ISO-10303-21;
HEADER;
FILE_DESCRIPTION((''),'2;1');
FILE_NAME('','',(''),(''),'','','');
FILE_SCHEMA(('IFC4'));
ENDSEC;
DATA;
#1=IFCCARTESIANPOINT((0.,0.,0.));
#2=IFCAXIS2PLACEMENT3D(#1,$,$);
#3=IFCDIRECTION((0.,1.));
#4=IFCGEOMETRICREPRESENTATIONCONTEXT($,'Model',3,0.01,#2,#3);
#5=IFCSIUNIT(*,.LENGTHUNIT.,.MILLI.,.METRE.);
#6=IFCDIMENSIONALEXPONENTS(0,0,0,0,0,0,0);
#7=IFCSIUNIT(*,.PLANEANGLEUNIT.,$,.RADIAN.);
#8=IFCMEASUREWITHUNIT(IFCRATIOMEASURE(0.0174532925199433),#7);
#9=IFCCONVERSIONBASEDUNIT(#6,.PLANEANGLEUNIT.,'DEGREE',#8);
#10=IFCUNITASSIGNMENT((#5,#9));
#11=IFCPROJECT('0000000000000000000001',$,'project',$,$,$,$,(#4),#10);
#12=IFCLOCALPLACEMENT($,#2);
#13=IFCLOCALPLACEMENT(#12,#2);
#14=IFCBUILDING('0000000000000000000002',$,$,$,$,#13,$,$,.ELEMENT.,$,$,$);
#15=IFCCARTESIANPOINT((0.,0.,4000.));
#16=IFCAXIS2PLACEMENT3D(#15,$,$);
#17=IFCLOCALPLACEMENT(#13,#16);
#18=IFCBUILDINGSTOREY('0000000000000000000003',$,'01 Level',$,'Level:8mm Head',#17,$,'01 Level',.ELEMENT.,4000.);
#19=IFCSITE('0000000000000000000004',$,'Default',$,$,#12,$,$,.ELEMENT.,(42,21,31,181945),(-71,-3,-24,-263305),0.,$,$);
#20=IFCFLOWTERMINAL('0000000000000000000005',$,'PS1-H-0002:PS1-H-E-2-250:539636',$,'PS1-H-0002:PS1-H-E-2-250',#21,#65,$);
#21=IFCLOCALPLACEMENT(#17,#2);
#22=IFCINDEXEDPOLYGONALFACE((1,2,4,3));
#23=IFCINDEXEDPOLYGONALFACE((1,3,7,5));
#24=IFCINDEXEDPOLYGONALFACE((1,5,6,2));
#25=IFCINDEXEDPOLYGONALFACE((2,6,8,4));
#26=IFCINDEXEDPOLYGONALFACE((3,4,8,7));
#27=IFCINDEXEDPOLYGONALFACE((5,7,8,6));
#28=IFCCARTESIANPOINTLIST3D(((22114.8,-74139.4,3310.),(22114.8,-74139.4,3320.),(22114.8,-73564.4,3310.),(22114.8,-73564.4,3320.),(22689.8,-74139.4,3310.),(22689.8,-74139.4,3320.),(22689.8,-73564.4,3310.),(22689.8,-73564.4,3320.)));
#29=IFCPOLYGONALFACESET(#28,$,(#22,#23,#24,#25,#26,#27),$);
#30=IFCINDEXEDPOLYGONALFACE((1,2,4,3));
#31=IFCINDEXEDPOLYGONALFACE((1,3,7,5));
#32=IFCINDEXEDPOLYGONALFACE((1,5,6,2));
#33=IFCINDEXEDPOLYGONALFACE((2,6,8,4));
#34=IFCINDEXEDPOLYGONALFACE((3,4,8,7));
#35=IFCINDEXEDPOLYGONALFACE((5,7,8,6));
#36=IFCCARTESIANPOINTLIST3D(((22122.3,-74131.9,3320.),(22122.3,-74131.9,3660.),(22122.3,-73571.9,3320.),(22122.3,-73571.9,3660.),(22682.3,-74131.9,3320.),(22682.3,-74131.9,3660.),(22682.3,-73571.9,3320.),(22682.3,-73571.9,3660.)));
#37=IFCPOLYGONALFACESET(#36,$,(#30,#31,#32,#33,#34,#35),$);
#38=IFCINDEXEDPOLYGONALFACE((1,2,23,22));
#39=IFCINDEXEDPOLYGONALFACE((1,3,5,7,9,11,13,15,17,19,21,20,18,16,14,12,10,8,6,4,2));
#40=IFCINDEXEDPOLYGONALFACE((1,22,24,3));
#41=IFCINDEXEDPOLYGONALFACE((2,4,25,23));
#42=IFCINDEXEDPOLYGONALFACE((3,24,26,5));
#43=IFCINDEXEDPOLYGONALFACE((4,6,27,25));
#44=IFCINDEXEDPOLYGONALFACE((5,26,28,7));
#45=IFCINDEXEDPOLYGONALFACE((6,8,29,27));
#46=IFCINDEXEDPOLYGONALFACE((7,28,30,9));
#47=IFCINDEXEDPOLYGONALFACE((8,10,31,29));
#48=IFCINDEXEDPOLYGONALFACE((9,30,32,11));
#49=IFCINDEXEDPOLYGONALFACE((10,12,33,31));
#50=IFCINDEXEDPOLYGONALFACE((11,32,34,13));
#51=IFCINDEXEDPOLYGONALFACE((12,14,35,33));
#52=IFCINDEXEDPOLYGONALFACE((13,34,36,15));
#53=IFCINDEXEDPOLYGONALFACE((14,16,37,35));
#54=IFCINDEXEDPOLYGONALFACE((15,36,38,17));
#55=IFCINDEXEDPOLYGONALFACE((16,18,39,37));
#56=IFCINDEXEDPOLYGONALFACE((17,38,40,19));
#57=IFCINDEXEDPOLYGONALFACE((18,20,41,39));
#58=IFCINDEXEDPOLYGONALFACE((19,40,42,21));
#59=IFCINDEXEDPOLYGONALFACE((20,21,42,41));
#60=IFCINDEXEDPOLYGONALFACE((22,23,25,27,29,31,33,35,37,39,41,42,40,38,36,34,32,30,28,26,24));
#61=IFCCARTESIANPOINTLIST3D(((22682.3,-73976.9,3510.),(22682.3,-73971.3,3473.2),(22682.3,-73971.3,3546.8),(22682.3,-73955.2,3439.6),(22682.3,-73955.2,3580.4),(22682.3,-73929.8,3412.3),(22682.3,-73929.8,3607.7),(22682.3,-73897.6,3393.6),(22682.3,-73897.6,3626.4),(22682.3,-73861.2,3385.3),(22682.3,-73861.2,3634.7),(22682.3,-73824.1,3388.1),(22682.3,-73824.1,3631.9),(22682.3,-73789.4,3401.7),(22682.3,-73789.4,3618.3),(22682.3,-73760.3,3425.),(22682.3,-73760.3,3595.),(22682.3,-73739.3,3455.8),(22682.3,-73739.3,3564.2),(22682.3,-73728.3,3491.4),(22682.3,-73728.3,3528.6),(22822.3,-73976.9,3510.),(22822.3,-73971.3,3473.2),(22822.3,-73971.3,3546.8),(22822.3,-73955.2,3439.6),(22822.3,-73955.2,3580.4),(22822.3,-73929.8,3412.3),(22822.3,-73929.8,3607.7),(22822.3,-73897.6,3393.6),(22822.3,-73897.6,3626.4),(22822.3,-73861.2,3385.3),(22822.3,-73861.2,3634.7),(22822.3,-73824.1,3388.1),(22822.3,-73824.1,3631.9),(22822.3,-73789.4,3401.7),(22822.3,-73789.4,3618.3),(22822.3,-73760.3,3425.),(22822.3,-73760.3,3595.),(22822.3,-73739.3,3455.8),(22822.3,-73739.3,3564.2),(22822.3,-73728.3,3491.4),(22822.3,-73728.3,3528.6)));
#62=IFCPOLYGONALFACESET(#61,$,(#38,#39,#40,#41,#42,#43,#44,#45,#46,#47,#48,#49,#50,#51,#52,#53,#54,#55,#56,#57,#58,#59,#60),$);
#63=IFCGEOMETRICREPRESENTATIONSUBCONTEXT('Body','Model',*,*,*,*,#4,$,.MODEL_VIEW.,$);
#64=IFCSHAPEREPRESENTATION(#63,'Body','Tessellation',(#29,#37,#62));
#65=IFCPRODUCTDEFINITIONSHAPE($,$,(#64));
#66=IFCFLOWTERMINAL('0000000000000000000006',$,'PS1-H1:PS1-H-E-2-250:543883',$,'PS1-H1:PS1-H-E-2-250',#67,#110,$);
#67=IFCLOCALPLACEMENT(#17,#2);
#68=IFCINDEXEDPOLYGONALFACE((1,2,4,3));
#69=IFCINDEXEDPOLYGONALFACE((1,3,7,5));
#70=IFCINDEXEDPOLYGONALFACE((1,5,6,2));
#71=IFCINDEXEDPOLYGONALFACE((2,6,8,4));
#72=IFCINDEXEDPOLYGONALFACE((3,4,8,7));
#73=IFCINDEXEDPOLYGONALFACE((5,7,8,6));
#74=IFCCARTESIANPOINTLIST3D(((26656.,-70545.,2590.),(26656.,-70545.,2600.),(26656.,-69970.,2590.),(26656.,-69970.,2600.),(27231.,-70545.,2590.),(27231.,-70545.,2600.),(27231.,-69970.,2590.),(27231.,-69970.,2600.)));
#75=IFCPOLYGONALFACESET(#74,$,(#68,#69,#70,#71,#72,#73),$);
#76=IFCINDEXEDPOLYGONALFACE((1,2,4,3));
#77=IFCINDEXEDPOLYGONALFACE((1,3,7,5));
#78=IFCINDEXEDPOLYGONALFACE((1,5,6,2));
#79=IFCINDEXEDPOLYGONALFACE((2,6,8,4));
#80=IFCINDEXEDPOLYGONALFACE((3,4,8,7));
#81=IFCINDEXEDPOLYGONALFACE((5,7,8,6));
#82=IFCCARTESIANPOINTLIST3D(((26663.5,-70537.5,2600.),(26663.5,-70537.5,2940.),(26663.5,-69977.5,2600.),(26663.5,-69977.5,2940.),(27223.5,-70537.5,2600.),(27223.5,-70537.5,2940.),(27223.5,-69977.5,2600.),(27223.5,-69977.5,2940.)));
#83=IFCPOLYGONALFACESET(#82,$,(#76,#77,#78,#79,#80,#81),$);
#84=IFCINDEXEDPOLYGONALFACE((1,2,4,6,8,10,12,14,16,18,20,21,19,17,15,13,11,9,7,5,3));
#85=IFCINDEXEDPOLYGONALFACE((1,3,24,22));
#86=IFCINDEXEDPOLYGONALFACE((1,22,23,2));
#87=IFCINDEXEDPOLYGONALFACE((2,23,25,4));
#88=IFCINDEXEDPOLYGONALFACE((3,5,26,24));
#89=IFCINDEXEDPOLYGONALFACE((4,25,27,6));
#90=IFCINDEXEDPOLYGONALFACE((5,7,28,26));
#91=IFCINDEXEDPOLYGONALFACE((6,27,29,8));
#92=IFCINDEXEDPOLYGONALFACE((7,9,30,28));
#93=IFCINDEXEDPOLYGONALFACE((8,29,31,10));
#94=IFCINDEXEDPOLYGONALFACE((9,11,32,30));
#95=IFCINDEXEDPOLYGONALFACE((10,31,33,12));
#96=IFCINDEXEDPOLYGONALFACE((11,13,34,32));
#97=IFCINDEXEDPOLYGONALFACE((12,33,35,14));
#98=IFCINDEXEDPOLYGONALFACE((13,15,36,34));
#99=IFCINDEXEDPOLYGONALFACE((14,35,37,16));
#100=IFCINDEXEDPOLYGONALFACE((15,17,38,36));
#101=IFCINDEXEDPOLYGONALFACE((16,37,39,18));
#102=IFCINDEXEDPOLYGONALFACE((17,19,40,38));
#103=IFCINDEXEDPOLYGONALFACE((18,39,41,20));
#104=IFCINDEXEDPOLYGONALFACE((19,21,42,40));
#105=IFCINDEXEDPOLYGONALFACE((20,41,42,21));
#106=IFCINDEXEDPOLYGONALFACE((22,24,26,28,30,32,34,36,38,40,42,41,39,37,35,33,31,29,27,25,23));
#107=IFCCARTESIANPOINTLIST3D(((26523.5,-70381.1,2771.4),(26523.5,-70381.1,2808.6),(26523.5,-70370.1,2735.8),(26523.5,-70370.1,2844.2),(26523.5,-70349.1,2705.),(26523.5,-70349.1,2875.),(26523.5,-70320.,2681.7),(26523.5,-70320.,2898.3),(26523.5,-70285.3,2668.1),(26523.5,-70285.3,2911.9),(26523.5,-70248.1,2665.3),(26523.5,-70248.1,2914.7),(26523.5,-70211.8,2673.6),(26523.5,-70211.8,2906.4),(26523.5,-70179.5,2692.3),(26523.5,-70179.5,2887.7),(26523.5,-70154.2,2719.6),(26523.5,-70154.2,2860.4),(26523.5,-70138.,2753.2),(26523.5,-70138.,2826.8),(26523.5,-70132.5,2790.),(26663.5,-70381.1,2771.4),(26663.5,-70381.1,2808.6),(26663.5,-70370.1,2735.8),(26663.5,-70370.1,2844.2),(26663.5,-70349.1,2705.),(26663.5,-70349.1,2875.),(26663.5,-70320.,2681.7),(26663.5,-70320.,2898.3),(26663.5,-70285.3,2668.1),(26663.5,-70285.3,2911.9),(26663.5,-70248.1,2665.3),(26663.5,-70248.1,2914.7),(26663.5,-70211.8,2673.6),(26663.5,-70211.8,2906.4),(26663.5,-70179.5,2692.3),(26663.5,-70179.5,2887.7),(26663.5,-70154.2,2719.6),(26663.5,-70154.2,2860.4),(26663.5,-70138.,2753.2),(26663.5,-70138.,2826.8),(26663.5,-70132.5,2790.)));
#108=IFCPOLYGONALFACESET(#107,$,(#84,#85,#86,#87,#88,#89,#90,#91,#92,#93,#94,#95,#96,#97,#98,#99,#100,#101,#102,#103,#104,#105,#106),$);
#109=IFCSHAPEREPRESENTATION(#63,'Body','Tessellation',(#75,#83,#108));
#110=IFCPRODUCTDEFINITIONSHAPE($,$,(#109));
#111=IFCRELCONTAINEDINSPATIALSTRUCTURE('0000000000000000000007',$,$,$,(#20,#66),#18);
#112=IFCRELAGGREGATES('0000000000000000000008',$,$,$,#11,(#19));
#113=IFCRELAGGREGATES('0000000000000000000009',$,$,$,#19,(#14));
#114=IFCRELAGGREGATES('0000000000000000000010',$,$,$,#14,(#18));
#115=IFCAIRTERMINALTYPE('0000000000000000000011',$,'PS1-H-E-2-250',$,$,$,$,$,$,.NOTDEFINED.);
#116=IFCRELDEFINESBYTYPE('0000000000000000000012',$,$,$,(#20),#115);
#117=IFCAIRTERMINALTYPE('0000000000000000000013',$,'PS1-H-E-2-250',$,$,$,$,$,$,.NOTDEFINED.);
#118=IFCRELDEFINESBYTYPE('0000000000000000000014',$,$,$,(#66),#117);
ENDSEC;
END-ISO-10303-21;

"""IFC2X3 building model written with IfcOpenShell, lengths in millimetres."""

from ifc_helpers import new_model, entity, si_unit, converted_unit, direction, frame, frame_2d, origin, origin_2d_with_axis, place, context, subcontext, project, spatial, rectangle, circle, extrude, source, transform, mapped, type_object, type_shapes, element, save


model = new_model("IFC2X3")

# Units and contexts
model_context = context("Model", 3, precision=0.01, world=origin(), true_north=direction((0.0, 1.0)))
body_context = subcontext(model_context, "Body", "Model", "MODEL_VIEW")
ifc_project = project(units=[si_unit("LENGTHUNIT", "METRE", prefix="MILLI"), converted_unit("PLANEANGLEUNIT", "DEGREE", entity("IfcRatioMeasure", 0.0174532925199433), si_unit("PLANEANGLEUNIT", "RADIAN"), dimensions=[0, 0, 0, 0, 0, 0, 0])], contexts=[model_context])

# Site, building, storey
site_placement = place(None, origin())
site = spatial("IfcSite", under=ifc_project, at=site_placement, Name="Default", CompositionType="ELEMENT", RefLatitude=(42, 21, 31, 181945), RefLongitude=(-71, -3, -24, -263305), RefElevation=0.0)
building_placement = place(site_placement, origin())
building = spatial("IfcBuilding", under=site, at=building_placement, CompositionType="ELEMENT")
storey_placement = place(building_placement, frame((0.0, 0.0, 4000.0)))
storey = spatial("IfcBuildingStorey", under=building, at=storey_placement, Name="01 Level", ObjectType="Level:8mm Head", LongName="01 Level", CompositionType="ELEMENT", Elevation=4000.0)

# Flow terminals
air_terminal_type_1 = type_object("IfcAirTerminalType", Name="PS1-H-E-2-250", PredefinedType="NOTDEFINED")
shared_shape_1 = source(origin(), body_context, "Body", "SweptSolid", [
    extrude(rectangle(XDim=575.0, YDim=575.0, at=origin_2d_with_axis()), frame((0.0, 0.0, -10.0), z_axis=(0.0, 0.0, 1.0), x_axis=(-1.0, 0.0, 0.0)), (0.0, 0.0, 1.0), 10.0),
    extrude(rectangle(XDim=560.0, YDim=560.0, at=origin_2d_with_axis()), frame((0.0, 0.0, 0.0), z_axis=(0.0, 0.0, 1.0), x_axis=(-1.0, 0.0, 0.0)), (0.0, 0.0, 1.0), 340.0),
    extrude(circle(Radius=125.0, at=frame_2d((0.0, 0.0), x_axis=(1.0, 0.0))), frame((-420.0, 0.0, 190.0), z_axis=(1.0, 0.0, 0.0), x_axis=(0.0, 1.0, 0.0)), (0.0, 0.0, 1.0), 140.0),
])
type_shapes(air_terminal_type_1, [shared_shape_1])
flow_terminal_1_placement = place(storey_placement, frame((22402.3, -73851.9, 3320.0), z_axis=(0.0, 0.0, 1.0), x_axis=(-1.0, 0.0, 0.0)))
element("IfcFlowTerminal", 1, at=flow_terminal_1_placement, inside=storey, type_object=air_terminal_type_1, Name="PS1-H-0002:PS1-H-E-2-250:539636", ObjectType="PS1-H-0002:PS1-H-E-2-250", context=body_context, shape_type="MappedRepresentation", body=[
    mapped(shared_shape_1, transform((0.0, 0.0, 0.0), scale=1.0)),
])
air_terminal_type_2 = type_object("IfcAirTerminalType", Name="PS1-H-E-2-250", PredefinedType="NOTDEFINED")
shared_shape_2 = source(origin(), body_context, "Body", "SweptSolid", [
    extrude(rectangle(XDim=575.0, YDim=575.0, at=origin_2d_with_axis()), frame((0.0, 0.0, -10.0), z_axis=(0.0, 0.0, 1.0), x_axis=(-1.0, 0.0, 0.0)), (0.0, 0.0, 1.0), 10.0),
    extrude(rectangle(XDim=560.0, YDim=560.0, at=origin_2d_with_axis()), frame((0.0, 0.0, 0.0), z_axis=(0.0, 0.0, 1.0), x_axis=(-1.0, 0.0, 0.0)), (0.0, 0.0, 1.0), 340.0),
    extrude(circle(Radius=125.0, at=frame_2d((0.0, 0.0), x_axis=(1.0, 0.0))), frame((-420.0, 0.0, 190.0), z_axis=(1.0, 0.0, 0.0), x_axis=(0.0, 1.0, 0.0)), (0.0, 0.0, 1.0), 140.0),
])
type_shapes(air_terminal_type_2, [shared_shape_2])
flow_terminal_2_placement = place(storey_placement, frame((26943.5, -70257.5, 2600.0)))
element("IfcFlowTerminal", 2, at=flow_terminal_2_placement, inside=storey, type_object=air_terminal_type_2, Name="PS1-H1:PS1-H-E-2-250:543883", ObjectType="PS1-H1:PS1-H-E-2-250", context=body_context, shape_type="MappedRepresentation", body=[
    mapped(shared_shape_2, transform((0.0, 0.0, 0.0), scale=1.0)),
])

save(model, "model.ifc")
